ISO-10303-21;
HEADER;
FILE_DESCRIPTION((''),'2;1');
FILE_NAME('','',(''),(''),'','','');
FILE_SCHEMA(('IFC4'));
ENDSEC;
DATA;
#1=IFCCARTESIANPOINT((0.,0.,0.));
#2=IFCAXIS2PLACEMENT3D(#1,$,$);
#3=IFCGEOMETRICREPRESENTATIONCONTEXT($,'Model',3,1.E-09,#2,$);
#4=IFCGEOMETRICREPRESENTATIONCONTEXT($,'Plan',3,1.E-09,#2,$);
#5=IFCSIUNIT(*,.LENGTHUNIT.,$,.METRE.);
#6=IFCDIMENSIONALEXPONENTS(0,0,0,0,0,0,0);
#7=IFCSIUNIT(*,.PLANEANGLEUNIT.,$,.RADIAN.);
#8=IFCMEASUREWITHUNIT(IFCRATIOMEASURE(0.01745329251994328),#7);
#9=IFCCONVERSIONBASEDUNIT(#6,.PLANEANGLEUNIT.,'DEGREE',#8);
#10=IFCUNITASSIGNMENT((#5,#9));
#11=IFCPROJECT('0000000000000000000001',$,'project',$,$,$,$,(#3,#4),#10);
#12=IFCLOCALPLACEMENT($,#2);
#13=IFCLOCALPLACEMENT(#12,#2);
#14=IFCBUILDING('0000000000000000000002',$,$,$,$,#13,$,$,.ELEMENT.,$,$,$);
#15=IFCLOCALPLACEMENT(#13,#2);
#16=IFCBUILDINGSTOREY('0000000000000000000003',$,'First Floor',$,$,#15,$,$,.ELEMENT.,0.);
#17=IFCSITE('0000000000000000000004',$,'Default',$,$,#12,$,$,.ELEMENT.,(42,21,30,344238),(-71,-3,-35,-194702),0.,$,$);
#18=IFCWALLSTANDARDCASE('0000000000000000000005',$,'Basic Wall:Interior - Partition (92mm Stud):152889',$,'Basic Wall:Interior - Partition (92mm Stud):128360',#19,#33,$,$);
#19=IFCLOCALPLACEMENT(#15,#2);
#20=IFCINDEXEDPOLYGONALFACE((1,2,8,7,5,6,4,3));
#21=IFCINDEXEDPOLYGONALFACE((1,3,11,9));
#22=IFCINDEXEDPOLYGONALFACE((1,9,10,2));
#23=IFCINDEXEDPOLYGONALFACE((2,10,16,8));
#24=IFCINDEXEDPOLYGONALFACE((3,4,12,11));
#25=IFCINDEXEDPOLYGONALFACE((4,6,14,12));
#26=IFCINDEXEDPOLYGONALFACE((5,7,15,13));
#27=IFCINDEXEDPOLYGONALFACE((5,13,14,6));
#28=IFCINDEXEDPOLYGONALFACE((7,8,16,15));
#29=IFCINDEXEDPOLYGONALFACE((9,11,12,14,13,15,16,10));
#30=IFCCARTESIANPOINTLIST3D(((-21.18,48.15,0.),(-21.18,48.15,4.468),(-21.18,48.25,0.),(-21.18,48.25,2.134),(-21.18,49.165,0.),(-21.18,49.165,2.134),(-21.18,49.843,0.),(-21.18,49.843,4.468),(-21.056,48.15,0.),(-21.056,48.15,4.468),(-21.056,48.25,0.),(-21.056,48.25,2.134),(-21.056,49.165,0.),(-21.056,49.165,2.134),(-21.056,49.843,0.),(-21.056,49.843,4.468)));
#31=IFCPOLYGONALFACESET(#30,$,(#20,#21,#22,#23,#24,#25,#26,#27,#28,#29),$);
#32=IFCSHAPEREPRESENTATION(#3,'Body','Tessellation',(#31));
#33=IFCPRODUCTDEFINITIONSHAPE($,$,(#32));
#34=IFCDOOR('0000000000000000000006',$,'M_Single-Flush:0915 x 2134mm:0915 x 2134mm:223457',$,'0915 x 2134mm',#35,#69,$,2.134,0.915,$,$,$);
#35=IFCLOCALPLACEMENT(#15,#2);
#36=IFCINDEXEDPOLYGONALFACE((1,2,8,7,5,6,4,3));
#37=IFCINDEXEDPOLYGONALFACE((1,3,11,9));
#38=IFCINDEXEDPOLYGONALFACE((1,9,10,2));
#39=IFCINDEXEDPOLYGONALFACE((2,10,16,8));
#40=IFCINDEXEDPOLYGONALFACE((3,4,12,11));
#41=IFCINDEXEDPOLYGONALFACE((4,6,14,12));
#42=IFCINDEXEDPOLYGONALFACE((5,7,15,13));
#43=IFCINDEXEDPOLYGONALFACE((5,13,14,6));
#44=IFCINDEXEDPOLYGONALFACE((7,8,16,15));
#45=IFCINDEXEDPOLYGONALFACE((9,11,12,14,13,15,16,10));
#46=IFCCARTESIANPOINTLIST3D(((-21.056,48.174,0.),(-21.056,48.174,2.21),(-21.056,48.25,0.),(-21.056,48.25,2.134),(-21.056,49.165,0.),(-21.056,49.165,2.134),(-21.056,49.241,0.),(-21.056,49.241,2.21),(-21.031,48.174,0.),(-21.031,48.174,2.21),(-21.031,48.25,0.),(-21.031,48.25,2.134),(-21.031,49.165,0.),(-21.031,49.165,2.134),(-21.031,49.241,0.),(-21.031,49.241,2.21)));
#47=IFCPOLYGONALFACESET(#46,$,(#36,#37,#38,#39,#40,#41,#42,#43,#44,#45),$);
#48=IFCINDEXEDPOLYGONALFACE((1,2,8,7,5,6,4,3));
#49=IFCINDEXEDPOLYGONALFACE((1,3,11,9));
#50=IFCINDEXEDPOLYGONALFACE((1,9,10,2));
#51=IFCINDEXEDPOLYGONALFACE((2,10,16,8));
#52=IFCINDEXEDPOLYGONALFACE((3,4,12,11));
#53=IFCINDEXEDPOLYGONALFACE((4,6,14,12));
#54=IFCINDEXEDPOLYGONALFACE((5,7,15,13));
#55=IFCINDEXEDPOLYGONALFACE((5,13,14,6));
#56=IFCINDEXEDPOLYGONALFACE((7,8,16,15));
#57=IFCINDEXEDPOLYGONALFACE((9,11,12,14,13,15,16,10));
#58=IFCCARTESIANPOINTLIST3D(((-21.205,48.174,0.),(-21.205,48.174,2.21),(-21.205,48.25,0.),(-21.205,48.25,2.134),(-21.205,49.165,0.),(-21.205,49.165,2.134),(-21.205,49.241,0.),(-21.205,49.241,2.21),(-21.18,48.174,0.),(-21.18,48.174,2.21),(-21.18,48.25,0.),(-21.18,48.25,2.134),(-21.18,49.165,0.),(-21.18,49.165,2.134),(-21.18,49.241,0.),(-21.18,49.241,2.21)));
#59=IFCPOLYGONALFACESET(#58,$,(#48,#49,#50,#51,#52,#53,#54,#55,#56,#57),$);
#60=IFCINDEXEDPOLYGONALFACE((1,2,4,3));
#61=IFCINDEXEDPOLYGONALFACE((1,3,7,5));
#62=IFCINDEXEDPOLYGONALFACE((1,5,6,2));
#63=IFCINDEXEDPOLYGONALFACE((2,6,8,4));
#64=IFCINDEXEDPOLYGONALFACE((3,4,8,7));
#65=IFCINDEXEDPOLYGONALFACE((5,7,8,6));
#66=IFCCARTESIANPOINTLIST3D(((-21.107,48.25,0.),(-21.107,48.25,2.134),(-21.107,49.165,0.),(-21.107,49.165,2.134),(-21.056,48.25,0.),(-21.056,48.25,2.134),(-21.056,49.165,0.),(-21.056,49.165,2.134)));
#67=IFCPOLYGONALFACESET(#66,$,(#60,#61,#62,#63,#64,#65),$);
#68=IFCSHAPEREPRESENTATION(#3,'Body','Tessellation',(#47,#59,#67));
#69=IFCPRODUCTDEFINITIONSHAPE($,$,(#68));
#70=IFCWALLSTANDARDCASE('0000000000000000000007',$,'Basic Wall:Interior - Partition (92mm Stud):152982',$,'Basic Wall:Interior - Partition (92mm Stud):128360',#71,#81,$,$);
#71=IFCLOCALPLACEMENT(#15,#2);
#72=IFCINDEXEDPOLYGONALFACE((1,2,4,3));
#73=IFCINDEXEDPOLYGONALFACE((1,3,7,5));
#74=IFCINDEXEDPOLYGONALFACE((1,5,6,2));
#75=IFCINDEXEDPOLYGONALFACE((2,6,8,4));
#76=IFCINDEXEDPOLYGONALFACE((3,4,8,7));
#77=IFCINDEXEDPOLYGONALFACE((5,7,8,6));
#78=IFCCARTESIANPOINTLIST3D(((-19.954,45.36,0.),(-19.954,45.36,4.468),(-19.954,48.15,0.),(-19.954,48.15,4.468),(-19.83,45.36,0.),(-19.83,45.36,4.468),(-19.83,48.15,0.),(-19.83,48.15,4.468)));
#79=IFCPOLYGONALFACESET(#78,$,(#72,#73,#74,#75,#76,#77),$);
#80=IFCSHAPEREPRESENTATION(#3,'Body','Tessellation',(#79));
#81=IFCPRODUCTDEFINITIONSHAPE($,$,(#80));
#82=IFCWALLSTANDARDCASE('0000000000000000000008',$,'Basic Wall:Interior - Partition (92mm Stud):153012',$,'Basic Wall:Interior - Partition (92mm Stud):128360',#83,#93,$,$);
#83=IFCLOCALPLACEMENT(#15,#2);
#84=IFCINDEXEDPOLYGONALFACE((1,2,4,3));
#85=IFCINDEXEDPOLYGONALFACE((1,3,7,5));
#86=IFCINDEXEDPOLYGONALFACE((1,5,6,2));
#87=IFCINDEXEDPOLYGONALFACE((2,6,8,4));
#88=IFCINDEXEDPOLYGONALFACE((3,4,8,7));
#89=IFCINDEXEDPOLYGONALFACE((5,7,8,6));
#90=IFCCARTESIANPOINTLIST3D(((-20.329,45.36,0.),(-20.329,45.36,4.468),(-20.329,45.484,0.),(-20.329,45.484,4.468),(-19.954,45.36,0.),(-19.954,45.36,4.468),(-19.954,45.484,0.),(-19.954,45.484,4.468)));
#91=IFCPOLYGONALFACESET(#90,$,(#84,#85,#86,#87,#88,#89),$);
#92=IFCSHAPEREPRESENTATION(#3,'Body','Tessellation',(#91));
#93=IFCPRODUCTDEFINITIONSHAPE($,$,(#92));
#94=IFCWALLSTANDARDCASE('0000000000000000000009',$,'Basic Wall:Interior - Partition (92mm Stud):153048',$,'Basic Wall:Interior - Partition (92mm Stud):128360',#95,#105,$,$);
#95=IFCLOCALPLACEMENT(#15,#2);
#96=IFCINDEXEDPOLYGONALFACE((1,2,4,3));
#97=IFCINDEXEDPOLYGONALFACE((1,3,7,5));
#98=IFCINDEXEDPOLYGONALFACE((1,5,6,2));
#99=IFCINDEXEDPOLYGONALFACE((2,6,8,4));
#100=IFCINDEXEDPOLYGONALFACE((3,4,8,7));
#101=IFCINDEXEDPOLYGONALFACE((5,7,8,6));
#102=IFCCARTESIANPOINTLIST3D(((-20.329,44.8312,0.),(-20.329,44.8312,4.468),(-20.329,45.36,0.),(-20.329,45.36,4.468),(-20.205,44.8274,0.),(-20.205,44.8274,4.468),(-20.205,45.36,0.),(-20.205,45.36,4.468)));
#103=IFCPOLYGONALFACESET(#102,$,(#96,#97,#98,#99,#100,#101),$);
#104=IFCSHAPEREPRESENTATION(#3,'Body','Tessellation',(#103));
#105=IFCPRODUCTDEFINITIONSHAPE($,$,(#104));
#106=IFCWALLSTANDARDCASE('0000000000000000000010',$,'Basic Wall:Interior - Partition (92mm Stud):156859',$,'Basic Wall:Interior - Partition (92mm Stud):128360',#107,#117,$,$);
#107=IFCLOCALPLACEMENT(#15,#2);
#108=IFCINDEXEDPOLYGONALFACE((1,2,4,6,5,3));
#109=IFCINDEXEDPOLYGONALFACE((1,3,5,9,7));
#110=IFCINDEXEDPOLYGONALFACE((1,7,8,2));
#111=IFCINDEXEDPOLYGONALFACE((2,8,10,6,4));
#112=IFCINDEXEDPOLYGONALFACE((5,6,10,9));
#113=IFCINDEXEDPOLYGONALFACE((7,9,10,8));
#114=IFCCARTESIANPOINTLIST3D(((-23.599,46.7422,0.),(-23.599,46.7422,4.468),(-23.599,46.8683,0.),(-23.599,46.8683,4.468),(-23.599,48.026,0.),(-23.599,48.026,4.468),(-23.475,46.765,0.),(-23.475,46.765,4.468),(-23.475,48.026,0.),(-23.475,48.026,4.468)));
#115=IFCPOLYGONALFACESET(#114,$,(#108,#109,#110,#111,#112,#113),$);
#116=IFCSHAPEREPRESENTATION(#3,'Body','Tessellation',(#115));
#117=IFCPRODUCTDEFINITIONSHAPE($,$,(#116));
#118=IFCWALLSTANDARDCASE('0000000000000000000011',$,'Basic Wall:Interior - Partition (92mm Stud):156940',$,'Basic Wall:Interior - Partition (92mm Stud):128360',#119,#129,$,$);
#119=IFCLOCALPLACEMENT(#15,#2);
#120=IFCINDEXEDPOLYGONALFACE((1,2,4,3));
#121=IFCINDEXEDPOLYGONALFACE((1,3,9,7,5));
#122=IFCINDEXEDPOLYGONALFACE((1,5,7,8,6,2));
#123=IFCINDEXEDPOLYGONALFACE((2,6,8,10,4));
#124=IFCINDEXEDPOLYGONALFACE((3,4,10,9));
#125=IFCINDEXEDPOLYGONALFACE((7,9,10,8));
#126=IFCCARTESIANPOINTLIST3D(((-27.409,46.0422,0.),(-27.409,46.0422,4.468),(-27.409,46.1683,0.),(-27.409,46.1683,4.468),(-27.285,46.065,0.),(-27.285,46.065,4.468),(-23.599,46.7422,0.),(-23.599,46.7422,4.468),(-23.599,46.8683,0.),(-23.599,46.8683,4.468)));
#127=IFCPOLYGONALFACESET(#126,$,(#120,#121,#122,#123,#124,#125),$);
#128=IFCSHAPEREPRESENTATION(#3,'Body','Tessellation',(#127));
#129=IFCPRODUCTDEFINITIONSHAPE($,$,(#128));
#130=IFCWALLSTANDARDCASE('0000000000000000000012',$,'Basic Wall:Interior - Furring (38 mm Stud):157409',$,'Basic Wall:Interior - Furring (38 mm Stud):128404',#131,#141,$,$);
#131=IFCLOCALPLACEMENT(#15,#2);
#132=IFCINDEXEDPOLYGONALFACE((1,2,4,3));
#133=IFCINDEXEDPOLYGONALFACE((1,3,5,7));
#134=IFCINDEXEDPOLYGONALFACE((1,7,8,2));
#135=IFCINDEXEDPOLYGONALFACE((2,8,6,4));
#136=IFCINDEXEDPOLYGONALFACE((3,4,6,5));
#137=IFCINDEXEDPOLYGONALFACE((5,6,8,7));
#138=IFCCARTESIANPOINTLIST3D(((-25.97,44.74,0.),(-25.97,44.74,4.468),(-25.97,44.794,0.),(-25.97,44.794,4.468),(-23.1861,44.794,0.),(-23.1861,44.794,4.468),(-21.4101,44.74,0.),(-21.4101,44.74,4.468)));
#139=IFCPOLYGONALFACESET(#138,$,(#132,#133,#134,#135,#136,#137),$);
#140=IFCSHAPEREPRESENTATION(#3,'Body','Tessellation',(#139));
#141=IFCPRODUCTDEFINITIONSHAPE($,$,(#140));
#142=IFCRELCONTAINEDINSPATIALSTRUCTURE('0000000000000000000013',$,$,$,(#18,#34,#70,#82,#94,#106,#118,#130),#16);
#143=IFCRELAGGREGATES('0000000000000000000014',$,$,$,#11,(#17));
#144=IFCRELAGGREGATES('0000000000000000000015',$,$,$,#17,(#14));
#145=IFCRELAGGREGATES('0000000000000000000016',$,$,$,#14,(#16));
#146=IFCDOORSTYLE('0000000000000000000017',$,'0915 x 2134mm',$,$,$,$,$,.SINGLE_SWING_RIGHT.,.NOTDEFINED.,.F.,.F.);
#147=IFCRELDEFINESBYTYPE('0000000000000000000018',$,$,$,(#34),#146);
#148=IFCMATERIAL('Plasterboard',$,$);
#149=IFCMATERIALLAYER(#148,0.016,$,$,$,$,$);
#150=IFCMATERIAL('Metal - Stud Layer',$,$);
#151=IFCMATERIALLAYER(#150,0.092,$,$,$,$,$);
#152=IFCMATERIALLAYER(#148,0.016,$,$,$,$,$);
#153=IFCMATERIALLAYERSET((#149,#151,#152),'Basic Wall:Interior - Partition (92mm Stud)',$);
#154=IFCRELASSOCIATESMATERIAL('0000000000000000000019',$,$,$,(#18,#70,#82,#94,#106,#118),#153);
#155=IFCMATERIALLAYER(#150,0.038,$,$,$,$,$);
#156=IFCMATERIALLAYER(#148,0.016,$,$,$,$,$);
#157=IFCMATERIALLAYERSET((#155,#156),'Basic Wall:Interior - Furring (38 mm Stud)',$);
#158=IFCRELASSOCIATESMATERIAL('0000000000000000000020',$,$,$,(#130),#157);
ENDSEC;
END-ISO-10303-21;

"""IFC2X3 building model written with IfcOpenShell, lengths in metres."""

from ifc_helpers import new_model, entity, si_unit, converted_unit, frame, frame_2d, origin, origin_2d_with_axis, place, context, project, spatial, polyline, rectangle, outline, extrude, clip, bounded_halfspace, source, transform, mapped, material, layer, layer_set, layer_usage, type_object, type_shapes, element, fill, save


model = new_model("IFC2X3")

# Units and contexts
model_context = context("Model", 3, precision=1e-09, world=origin())
plan_context = context("Plan", 3, precision=1e-09, world=origin())
ifc_project = project(units=[si_unit("LENGTHUNIT", "METRE"), converted_unit("PLANEANGLEUNIT", "DEGREE", entity("IfcRatioMeasure", 0.01745329251994328), si_unit("PLANEANGLEUNIT", "RADIAN"), dimensions=[0, 0, 0, 0, 0, 0, 0])], contexts=[model_context, plan_context])

# Site, building, storey
site_placement = place(None, origin())
site = spatial("IfcSite", under=ifc_project, at=site_placement, Name="Default", CompositionType="ELEMENT", RefLatitude=(42, 21, 30, 344238), RefLongitude=(-71, -3, -35, -194702), RefElevation=0.0)
building_placement = place(site_placement, origin())
building = spatial("IfcBuilding", under=site, at=building_placement, CompositionType="ELEMENT")
storey_placement = place(building_placement, origin())
storey = spatial("IfcBuildingStorey", under=building, at=storey_placement, Name="First Floor", CompositionType="ELEMENT", Elevation=0.0)

# Wall, opening, door
ifc_material_1 = material(Name="Plasterboard")
ifc_layer_1 = layer(ifc_material_1, 0.016)
ifc_material_2 = material(Name="Metal - Stud Layer")
ifc_layer_2 = layer(ifc_material_2, 0.092)
ifc_layer_3 = layer(ifc_material_1, 0.016)
ifc_layer_set_1 = layer_set([ifc_layer_1, ifc_layer_2, ifc_layer_3], Name="Basic Wall:Interior - Partition (92mm Stud)")
ifc_layer_usage_1 = layer_usage(ifc_layer_set_1, "AXIS2", "NEGATIVE", 0.062)
wall_1_placement = place(storey_placement, frame((-21.118, 48.15, 0.0), z_axis=(0.0, 0.0, 1.0), x_axis=(0.0, 1.0, 0.0)))
wall_1 = element("IfcWallStandardCase", 1, at=wall_1_placement, inside=storey, material=ifc_layer_usage_1, Name="Basic Wall:Interior - Partition (92mm Stud):152889", ObjectType="Basic Wall:Interior - Partition (92mm Stud):128360", context=model_context, shape_type="SweptSolid", body=[
    extrude(rectangle(XDim=1.693, YDim=0.124, at=frame_2d((0.8465, 0.0), x_axis=(-1.0, 0.0))), origin(), (0.0, 0.0, 1.0), 4.468),
])
opening_1_placement = place(wall_1_placement, frame((1.015, 0.062, 0.0)))
opening_1 = element("IfcOpeningElement", 2, at=opening_1_placement, cuts=wall_1, ObjectType="Opening", context=model_context, shape_type="SweptSolid", body=[
    extrude(rectangle(XDim=0.915, YDim=2.134, at=frame_2d((1.067, 0.4575), x_axis=(0.0, 1.0))), frame((0.0, 0.0, 0.0), z_axis=(0.0, -1.0, 0.0), x_axis=(0.0, 0.0, 1.0)), (0.0, 0.0, 1.0), 0.124),
])
door_style_1 = type_object("IfcDoorStyle", Name="0915 x 2134mm", ConstructionType="NOTDEFINED", OperationType="SINGLE_SWING_RIGHT", ParameterTakesPrecedence=False, Sizeable=False)
shared_shape_1 = source(origin(), model_context, "Body", "SweptSolid", [
    extrude(outline(polyline([(-0.5335, -1.124), (0.5335, -1.124), (0.5335, 1.086), (0.4575, 1.086), (0.4575, -1.048), (-0.4575, -1.048), (-0.4575, 1.086), (-0.5335, 1.086), (-0.5335, -1.124)])), frame((0.4575, 0.124, 1.086), z_axis=(0.0, 1.0, 0.0), x_axis=(1.0, 0.0, 0.0)), (0.0, 0.0, 1.0), 0.025),
    extrude(outline(polyline([(-1.124, -0.5335), (1.086, -0.5335), (1.086, -0.4575), (-1.048, -0.4575), (-1.048, 0.4575), (1.086, 0.4575), (1.086, 0.5335), (-1.124, 0.5335), (-1.124, -0.5335)])), frame((0.4575, -0.025, 1.086), z_axis=(0.0, 1.0, 0.0), x_axis=(0.0, 0.0, -1.0)), (0.0, 0.0, 1.0), 0.025),
    extrude(rectangle(XDim=0.051, YDim=0.915, at=origin_2d_with_axis()), frame((0.4575, 0.0985, 0.0), z_axis=(0.0, 0.0, 1.0), x_axis=(0.0, 1.0, 0.0)), (0.0, 0.0, 1.0), 2.134),
])
type_shapes(door_style_1, [shared_shape_1])
door_1_placement = place(opening_1_placement, frame((0.0, 0.0, 0.0), z_axis=(0.0, 0.0, 1.0), x_axis=(-1.0, 0.0, 0.0)))
door_1 = element("IfcDoor", 3, at=door_1_placement, inside=storey, type_object=door_style_1, Name="M_Single-Flush:0915 x 2134mm:0915 x 2134mm:223457", ObjectType="0915 x 2134mm", OverallHeight=2.134, OverallWidth=0.915, context=model_context, shape_type="MappedRepresentation", body=[
    mapped(shared_shape_1, transform((0.0, 0.0, 0.0), scale=1.0)),
])
fill(opening_1, door_1)

# Walls
ifc_layer_usage_2 = layer_usage(ifc_layer_set_1, "AXIS2", "NEGATIVE", 0.062)
wall_2_placement = place(storey_placement, frame((-19.892, 48.15, 0.0), z_axis=(0.0, 0.0, 1.0), x_axis=(0.0, -1.0, 0.0)))
element("IfcWallStandardCase", 4, at=wall_2_placement, inside=storey, material=ifc_layer_usage_2, Name="Basic Wall:Interior - Partition (92mm Stud):152982", ObjectType="Basic Wall:Interior - Partition (92mm Stud):128360", context=model_context, shape_type="SweptSolid", body=[
    extrude(rectangle(XDim=2.79, YDim=0.124, at=frame_2d((1.395, 0.0), x_axis=(-1.0, 0.0))), origin(), (0.0, 0.0, 1.0), 4.468),
])
ifc_layer_usage_3 = layer_usage(ifc_layer_set_1, "AXIS2", "NEGATIVE", 0.062)
wall_3_placement = place(storey_placement, frame((-19.954, 45.422, 0.0), z_axis=(0.0, 0.0, 1.0), x_axis=(-1.0, 0.0, 0.0)))
element("IfcWallStandardCase", 5, at=wall_3_placement, inside=storey, material=ifc_layer_usage_3, Name="Basic Wall:Interior - Partition (92mm Stud):153012", ObjectType="Basic Wall:Interior - Partition (92mm Stud):128360", context=model_context, shape_type="SweptSolid", body=[
    extrude(rectangle(XDim=0.375, YDim=0.124, at=frame_2d((0.1875, 0.0), x_axis=(-1.0, 0.0))), origin(), (0.0, 0.0, 1.0), 4.468),
])
ifc_layer_usage_4 = layer_usage(ifc_layer_set_1, "AXIS2", "NEGATIVE", 0.062)
wall_4_placement = place(storey_placement, frame((-20.267, 45.36, 0.0), z_axis=(0.0, 0.0, 1.0), x_axis=(0.0, -1.0, 0.0)))
element("IfcWallStandardCase", 6, at=wall_4_placement, inside=storey, material=ifc_layer_usage_4, Name="Basic Wall:Interior - Partition (92mm Stud):153048", ObjectType="Basic Wall:Interior - Partition (92mm Stud):128360", context=model_context, shape_type="SweptSolid", body=[
    extrude(outline(polyline([(0.5288, -0.062), (0.5326, 0.062), (0.0, 0.062), (0.0, -0.062), (0.5288, -0.062)])), origin(), (0.0, 0.0, 1.0), 4.468),
])
ifc_layer_usage_5 = layer_usage(ifc_layer_set_1, "AXIS2", "NEGATIVE", 0.062)
wall_5_placement = place(storey_placement, frame((-23.537, 48.026, 0.0), z_axis=(0.0, 0.0, 1.0), x_axis=(0.0, -1.0, 0.0)))
element("IfcWallStandardCase", 7, at=wall_5_placement, inside=storey, material=ifc_layer_usage_5, Name="Basic Wall:Interior - Partition (92mm Stud):156859", ObjectType="Basic Wall:Interior - Partition (92mm Stud):128360", context=model_context, shape_type="SweptSolid", body=[
    extrude(outline(polyline([(1.2838, -0.062), (1.261, 0.062), (0.0, 0.062), (0.0, -0.062), (1.1577, -0.062), (1.2838, -0.062)])), origin(), (0.0, 0.0, 1.0), 4.468),
])
ifc_layer_usage_6 = layer_usage(ifc_layer_set_1, "AXIS2", "NEGATIVE", 0.062)
wall_6_placement = place(storey_placement, frame((-23.5878, 46.8073, 0.0), z_axis=(0.0, 0.0, 1.0), x_axis=(-0.983538, -0.180702, 0.0)))
element("IfcWallStandardCase", 8, at=wall_6_placement, inside=storey, material=ifc_layer_usage_6, Name="Basic Wall:Interior - Partition (92mm Stud):156940", ObjectType="Basic Wall:Interior - Partition (92mm Stud):128360", context=model_context, shape_type="SweptSolid", body=[
    extrude(outline(polyline([(3.8738, -0.062), (3.8966, 0.062), (3.7705, 0.062), (0.0228, 0.062), (0.0, -0.062), (3.8738, -0.062)])), origin(), (0.0, 0.0, 1.0), 4.468),
])
ifc_layer_4 = layer(ifc_material_2, 0.038)
ifc_layer_5 = layer(ifc_material_1, 0.016)
ifc_layer_set_2 = layer_set([ifc_layer_4, ifc_layer_5], Name="Basic Wall:Interior - Furring (38 mm Stud)")
ifc_layer_usage_7 = layer_usage(ifc_layer_set_2, "AXIS2", "POSITIVE", -0.027)
wall_7_placement = place(storey_placement, frame((-21.4101, 44.767, 0.0), z_axis=(0.0, 0.0, 1.0), x_axis=(-1.0, 0.0, 0.0)))
element("IfcWallStandardCase", 9, at=wall_7_placement, inside=storey, material=ifc_layer_usage_7, Name="Basic Wall:Interior - Furring (38 mm Stud):157409", ObjectType="Basic Wall:Interior - Furring (38 mm Stud):128404", context=model_context, shape_type="Clipping", body=[
    clip(extrude(rectangle(XDim=4.5599, YDim=0.054, at=frame_2d((2.2799, 0.0), x_axis=(-1.0, 0.0))), origin(), (0.0, 0.0, 1.0), 4.468), bounded_halfspace(frame((1.776, -0.027, 0.0), z_axis=(0.030391, 0.999538, 0.0), x_axis=(-0.999538, 0.030391, 0.0)), True, frame((1.776, -0.027, 0.0), z_axis=(0.030391, 0.999538, 0.0), x_axis=(-0.999538, 0.030391, 0.0)), polyline([(0.0, 0.0), (1.7768, 0.0), (1.7768, 4.468), (0.0, 4.468), (0.0, 0.0)]))),
])

save(model, "model.ifc")
